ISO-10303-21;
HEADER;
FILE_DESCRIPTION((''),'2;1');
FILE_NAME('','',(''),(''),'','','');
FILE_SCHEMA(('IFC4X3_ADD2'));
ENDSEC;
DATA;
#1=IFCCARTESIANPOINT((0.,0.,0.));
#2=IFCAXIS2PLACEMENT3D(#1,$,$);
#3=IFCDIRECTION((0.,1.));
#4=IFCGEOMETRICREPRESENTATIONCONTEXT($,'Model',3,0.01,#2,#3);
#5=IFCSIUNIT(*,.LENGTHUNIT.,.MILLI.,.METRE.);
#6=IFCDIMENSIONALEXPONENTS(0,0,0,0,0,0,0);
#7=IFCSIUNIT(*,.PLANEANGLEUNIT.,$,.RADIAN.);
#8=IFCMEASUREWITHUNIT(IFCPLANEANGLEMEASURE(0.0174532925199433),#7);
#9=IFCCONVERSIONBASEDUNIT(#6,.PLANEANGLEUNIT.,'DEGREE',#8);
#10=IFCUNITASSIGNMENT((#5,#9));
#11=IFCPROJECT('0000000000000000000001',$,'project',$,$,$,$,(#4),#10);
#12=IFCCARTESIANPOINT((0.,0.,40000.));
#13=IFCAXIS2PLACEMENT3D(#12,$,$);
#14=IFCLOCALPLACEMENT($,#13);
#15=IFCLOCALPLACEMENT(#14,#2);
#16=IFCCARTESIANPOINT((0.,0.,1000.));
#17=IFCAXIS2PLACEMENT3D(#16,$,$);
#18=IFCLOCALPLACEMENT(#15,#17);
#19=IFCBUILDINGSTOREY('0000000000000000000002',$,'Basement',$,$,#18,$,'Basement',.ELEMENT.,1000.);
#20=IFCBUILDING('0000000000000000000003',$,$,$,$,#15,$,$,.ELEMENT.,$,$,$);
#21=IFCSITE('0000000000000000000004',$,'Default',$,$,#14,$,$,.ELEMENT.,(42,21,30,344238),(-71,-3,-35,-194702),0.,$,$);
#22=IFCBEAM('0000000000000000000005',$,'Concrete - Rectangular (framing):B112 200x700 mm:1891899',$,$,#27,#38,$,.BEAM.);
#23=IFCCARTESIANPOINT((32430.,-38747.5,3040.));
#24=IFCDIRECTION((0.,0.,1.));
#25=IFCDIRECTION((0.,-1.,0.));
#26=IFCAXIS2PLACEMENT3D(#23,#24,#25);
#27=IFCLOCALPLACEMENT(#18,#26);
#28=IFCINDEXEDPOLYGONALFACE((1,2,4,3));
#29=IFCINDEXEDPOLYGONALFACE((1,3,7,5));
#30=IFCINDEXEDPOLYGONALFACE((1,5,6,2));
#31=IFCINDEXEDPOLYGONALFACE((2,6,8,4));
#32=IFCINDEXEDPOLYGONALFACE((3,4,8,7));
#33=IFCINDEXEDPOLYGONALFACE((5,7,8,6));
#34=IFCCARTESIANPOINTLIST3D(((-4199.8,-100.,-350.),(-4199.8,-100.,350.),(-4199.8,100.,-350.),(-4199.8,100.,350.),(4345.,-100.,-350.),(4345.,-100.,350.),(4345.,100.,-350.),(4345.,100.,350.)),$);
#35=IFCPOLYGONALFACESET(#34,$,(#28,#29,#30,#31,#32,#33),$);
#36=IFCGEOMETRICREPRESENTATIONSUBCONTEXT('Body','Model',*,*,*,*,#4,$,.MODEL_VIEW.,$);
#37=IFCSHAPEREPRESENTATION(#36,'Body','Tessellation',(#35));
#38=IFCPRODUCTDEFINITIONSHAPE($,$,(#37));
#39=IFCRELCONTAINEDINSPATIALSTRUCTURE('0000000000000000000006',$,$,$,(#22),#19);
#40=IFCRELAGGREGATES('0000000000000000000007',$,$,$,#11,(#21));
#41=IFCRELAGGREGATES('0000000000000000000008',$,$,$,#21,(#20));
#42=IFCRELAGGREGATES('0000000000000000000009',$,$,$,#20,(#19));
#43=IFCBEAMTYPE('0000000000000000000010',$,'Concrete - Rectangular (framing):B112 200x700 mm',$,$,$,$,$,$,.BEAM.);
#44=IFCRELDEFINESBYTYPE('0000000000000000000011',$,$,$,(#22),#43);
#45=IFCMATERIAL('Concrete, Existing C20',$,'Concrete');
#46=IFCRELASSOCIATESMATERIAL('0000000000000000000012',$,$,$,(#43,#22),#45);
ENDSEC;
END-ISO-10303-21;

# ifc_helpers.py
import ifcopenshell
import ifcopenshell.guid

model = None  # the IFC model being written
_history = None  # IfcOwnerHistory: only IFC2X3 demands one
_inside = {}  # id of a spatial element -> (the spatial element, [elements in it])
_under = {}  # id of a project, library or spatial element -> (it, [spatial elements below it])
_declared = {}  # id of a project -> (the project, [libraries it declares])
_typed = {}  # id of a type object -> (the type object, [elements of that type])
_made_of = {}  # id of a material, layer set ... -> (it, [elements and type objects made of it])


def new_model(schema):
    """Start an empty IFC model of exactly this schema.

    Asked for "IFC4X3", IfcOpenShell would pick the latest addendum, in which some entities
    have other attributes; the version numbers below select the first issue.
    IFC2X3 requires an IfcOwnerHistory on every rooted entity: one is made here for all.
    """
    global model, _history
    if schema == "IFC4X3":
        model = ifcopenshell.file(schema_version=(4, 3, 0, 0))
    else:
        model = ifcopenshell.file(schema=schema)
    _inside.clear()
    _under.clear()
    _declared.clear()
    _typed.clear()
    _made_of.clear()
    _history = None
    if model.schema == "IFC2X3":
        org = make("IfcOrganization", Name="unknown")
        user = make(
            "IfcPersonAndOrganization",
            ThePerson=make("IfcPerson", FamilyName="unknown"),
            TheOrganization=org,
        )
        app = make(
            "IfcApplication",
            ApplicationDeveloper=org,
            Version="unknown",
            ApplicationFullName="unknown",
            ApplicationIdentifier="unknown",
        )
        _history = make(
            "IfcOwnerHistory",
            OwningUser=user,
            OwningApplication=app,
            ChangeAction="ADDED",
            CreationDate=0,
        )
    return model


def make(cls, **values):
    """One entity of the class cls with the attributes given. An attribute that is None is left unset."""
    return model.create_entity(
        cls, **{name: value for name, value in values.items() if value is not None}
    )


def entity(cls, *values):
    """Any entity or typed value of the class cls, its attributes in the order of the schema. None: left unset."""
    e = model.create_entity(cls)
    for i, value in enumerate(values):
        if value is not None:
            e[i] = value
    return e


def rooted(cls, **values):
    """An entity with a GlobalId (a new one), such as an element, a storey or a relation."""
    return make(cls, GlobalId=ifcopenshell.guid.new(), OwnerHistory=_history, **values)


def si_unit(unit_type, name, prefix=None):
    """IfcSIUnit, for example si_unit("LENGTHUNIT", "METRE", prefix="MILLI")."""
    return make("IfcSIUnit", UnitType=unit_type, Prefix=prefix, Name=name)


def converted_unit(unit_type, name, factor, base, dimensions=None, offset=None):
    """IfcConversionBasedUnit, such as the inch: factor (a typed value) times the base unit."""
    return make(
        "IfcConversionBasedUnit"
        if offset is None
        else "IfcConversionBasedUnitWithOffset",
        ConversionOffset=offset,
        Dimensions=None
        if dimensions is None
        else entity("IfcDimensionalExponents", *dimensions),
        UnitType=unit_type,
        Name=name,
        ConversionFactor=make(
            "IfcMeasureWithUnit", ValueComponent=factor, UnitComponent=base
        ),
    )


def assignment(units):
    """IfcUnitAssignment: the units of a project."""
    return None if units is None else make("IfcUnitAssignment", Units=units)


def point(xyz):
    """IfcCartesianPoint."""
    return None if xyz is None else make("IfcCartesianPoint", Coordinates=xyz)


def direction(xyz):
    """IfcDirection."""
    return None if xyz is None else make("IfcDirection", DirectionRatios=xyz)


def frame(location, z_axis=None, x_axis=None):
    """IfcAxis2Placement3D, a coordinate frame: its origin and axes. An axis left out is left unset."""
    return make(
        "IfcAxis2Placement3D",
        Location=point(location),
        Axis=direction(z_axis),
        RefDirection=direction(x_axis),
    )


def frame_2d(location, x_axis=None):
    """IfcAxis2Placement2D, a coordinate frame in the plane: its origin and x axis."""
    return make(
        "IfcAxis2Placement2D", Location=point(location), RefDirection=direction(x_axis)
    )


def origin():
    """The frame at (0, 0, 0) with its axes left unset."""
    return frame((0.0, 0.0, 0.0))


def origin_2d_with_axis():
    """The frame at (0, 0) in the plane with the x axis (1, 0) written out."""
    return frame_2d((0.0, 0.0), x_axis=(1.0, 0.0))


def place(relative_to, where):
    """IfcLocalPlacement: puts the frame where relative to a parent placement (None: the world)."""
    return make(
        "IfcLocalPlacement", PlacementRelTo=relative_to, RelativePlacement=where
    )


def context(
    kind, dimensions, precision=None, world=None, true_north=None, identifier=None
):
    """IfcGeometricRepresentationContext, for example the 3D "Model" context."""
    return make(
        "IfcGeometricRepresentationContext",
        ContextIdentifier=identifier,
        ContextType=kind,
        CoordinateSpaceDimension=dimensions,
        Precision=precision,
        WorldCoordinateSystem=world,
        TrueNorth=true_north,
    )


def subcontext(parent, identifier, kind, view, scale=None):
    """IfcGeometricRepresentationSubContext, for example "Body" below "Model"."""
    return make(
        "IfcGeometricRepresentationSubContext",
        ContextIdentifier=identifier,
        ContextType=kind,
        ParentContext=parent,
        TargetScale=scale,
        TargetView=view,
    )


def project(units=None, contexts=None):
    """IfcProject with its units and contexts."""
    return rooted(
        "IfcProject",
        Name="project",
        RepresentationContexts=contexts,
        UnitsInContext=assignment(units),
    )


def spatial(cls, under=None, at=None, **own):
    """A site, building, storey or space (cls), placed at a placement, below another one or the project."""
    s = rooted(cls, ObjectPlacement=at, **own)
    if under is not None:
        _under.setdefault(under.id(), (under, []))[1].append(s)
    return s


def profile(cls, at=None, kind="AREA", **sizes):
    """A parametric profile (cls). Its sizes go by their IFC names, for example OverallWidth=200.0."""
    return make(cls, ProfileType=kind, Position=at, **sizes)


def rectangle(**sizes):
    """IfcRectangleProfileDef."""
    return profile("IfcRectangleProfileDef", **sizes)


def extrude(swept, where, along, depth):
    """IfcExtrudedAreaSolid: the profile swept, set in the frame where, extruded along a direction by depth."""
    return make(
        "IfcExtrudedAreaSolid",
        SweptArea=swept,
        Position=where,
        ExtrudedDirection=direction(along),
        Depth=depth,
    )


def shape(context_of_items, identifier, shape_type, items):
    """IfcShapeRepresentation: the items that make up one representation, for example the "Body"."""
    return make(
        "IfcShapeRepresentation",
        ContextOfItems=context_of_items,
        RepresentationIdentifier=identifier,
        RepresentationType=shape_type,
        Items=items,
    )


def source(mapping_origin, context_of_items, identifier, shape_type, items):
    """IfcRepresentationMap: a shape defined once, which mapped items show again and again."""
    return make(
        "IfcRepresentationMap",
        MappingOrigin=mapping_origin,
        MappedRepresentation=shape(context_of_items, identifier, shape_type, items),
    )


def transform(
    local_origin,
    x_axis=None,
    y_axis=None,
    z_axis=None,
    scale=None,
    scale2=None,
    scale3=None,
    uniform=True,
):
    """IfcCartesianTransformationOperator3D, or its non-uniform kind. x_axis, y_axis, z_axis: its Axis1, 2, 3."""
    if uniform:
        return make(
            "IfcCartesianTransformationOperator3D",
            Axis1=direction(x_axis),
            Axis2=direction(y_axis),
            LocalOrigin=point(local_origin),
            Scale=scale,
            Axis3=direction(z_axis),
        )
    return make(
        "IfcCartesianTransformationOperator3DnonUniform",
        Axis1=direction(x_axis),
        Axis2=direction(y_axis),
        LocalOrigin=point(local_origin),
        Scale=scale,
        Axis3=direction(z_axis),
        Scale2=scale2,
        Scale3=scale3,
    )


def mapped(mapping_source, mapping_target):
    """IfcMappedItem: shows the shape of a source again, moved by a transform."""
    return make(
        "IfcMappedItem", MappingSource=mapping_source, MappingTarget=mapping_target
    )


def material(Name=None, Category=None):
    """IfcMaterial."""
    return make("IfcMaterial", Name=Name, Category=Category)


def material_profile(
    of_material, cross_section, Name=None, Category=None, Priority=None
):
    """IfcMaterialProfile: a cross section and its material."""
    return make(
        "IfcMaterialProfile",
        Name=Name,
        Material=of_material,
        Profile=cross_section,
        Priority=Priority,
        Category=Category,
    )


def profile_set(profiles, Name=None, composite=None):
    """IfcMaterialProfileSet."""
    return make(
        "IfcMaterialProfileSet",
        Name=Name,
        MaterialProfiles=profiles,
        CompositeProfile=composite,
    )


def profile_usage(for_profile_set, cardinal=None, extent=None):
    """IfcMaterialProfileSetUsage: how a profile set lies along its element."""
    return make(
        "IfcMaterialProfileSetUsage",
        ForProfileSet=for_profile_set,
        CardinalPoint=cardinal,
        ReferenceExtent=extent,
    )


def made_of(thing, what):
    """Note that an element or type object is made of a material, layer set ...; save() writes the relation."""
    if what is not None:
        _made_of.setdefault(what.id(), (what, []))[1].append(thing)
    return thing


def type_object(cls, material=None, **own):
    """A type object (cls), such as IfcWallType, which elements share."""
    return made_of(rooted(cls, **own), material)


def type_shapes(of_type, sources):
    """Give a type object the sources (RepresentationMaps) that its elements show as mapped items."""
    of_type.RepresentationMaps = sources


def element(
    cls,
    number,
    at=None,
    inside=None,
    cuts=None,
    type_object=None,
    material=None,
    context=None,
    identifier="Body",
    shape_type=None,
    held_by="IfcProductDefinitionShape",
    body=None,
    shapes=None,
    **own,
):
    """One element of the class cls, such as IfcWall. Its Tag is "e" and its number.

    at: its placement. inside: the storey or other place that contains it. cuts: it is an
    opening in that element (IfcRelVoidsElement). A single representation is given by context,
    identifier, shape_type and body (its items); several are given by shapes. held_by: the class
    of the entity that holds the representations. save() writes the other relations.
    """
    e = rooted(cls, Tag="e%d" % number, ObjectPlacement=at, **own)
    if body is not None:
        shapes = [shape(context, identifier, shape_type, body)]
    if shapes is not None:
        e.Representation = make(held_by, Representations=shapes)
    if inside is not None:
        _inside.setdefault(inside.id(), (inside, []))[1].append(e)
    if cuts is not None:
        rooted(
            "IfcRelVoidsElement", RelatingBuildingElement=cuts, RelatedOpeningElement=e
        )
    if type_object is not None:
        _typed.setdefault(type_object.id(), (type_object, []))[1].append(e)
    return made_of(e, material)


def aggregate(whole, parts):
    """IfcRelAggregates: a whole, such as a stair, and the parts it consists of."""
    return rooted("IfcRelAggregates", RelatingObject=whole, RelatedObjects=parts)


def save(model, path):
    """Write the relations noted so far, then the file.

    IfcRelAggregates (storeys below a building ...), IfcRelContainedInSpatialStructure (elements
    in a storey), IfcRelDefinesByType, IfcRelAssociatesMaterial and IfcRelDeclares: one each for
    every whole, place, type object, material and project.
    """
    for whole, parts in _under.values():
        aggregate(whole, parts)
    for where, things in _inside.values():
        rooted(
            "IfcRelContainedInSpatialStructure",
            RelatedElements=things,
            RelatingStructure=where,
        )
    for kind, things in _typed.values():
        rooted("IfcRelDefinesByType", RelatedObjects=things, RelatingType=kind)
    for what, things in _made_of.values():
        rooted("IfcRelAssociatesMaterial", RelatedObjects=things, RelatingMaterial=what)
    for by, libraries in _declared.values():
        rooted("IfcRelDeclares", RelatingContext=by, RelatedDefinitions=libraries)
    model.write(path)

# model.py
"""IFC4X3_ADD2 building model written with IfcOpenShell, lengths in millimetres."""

from ifc_helpers import new_model, entity, si_unit, converted_unit, direction, frame, origin, origin_2d_with_axis, place, context, subcontext, project, spatial, rectangle, extrude, source, transform, mapped, material, material_profile, profile_set, profile_usage, type_object, type_shapes, element, save


model = new_model("IFC4X3_ADD2")

# Units and contexts
model_context = context("Model", 3, precision=0.01, world=origin(), true_north=direction((0.0, 1.0)))
body_context = subcontext(model_context, "Body", "Model", "MODEL_VIEW")
ifc_project = project(units=[si_unit("LENGTHUNIT", "METRE", prefix="MILLI"), converted_unit("PLANEANGLEUNIT", "DEGREE", entity("IfcPlaneAngleMeasure", 0.0174532925199433), si_unit("PLANEANGLEUNIT", "RADIAN"), dimensions=[0, 0, 0, 0, 0, 0, 0])], contexts=[model_context])

# Site, building, storey
site_placement = place(None, frame((0.0, 0.0, 40000.0)))
site = spatial("IfcSite", under=ifc_project, at=site_placement, Name="Default", CompositionType="ELEMENT", RefLatitude=(42, 21, 30, 344238), RefLongitude=(-71, -3, -35, -194702), RefElevation=0.0)
building_placement = place(site_placement, origin())
building = spatial("IfcBuilding", under=site, at=building_placement, CompositionType="ELEMENT")
storey_placement = place(building_placement, frame((0.0, 0.0, 1000.0)))
storey = spatial("IfcBuildingStorey", under=building, at=storey_placement, Name="Basement", LongName="Basement", CompositionType="ELEMENT", Elevation=1000.0)

# Shared definitions
ifc_material_1 = material(Name="Concrete, Existing C20", Category="Concrete")

# Beam
ifc_material_profile_1 = material_profile(ifc_material_1, rectangle(XDim=8579.8, YDim=200.0, at=origin_2d_with_axis()), Name="B112 200x700 mm")
ifc_profile_set_1 = profile_set([ifc_material_profile_1], Name="B112 200x700 mm")
ifc_profile_usage_1 = profile_usage(ifc_profile_set_1, cardinal=8)
beam_type_1 = type_object("IfcBeamType", Name="Concrete - Rectangular (framing):B112 200x700 mm", PredefinedType="BEAM", material=ifc_profile_set_1)
shared_shape_1 = source(origin(), body_context, "Body", "SweptSolid", [
    extrude(rectangle(XDim=8544.8, YDim=200.0, at=origin_2d_with_axis()), frame((72.6, 0.0, -350.0), z_axis=(0.0, 0.0, 1.0), x_axis=(-1.0, 0.0, 0.0)), (0.0, 0.0, 1.0), 700.0),
])
type_shapes(beam_type_1, [shared_shape_1])
beam_1_placement = place(storey_placement, frame((32430.0, -38747.5, 3040.0), z_axis=(0.0, 0.0, 1.0), x_axis=(0.0, -1.0, 0.0)))
element("IfcBeam", 1, at=beam_1_placement, inside=storey, type_object=beam_type_1, material=ifc_profile_usage_1, Name="Concrete - Rectangular (framing):B112 200x700 mm:1891899", PredefinedType="BEAM", context=body_context, shape_type="MappedRepresentation", body=[
    mapped(shared_shape_1, transform((0.0, 0.0, 0.0), scale=1.0)),
])

save(model, "model.ifc")
